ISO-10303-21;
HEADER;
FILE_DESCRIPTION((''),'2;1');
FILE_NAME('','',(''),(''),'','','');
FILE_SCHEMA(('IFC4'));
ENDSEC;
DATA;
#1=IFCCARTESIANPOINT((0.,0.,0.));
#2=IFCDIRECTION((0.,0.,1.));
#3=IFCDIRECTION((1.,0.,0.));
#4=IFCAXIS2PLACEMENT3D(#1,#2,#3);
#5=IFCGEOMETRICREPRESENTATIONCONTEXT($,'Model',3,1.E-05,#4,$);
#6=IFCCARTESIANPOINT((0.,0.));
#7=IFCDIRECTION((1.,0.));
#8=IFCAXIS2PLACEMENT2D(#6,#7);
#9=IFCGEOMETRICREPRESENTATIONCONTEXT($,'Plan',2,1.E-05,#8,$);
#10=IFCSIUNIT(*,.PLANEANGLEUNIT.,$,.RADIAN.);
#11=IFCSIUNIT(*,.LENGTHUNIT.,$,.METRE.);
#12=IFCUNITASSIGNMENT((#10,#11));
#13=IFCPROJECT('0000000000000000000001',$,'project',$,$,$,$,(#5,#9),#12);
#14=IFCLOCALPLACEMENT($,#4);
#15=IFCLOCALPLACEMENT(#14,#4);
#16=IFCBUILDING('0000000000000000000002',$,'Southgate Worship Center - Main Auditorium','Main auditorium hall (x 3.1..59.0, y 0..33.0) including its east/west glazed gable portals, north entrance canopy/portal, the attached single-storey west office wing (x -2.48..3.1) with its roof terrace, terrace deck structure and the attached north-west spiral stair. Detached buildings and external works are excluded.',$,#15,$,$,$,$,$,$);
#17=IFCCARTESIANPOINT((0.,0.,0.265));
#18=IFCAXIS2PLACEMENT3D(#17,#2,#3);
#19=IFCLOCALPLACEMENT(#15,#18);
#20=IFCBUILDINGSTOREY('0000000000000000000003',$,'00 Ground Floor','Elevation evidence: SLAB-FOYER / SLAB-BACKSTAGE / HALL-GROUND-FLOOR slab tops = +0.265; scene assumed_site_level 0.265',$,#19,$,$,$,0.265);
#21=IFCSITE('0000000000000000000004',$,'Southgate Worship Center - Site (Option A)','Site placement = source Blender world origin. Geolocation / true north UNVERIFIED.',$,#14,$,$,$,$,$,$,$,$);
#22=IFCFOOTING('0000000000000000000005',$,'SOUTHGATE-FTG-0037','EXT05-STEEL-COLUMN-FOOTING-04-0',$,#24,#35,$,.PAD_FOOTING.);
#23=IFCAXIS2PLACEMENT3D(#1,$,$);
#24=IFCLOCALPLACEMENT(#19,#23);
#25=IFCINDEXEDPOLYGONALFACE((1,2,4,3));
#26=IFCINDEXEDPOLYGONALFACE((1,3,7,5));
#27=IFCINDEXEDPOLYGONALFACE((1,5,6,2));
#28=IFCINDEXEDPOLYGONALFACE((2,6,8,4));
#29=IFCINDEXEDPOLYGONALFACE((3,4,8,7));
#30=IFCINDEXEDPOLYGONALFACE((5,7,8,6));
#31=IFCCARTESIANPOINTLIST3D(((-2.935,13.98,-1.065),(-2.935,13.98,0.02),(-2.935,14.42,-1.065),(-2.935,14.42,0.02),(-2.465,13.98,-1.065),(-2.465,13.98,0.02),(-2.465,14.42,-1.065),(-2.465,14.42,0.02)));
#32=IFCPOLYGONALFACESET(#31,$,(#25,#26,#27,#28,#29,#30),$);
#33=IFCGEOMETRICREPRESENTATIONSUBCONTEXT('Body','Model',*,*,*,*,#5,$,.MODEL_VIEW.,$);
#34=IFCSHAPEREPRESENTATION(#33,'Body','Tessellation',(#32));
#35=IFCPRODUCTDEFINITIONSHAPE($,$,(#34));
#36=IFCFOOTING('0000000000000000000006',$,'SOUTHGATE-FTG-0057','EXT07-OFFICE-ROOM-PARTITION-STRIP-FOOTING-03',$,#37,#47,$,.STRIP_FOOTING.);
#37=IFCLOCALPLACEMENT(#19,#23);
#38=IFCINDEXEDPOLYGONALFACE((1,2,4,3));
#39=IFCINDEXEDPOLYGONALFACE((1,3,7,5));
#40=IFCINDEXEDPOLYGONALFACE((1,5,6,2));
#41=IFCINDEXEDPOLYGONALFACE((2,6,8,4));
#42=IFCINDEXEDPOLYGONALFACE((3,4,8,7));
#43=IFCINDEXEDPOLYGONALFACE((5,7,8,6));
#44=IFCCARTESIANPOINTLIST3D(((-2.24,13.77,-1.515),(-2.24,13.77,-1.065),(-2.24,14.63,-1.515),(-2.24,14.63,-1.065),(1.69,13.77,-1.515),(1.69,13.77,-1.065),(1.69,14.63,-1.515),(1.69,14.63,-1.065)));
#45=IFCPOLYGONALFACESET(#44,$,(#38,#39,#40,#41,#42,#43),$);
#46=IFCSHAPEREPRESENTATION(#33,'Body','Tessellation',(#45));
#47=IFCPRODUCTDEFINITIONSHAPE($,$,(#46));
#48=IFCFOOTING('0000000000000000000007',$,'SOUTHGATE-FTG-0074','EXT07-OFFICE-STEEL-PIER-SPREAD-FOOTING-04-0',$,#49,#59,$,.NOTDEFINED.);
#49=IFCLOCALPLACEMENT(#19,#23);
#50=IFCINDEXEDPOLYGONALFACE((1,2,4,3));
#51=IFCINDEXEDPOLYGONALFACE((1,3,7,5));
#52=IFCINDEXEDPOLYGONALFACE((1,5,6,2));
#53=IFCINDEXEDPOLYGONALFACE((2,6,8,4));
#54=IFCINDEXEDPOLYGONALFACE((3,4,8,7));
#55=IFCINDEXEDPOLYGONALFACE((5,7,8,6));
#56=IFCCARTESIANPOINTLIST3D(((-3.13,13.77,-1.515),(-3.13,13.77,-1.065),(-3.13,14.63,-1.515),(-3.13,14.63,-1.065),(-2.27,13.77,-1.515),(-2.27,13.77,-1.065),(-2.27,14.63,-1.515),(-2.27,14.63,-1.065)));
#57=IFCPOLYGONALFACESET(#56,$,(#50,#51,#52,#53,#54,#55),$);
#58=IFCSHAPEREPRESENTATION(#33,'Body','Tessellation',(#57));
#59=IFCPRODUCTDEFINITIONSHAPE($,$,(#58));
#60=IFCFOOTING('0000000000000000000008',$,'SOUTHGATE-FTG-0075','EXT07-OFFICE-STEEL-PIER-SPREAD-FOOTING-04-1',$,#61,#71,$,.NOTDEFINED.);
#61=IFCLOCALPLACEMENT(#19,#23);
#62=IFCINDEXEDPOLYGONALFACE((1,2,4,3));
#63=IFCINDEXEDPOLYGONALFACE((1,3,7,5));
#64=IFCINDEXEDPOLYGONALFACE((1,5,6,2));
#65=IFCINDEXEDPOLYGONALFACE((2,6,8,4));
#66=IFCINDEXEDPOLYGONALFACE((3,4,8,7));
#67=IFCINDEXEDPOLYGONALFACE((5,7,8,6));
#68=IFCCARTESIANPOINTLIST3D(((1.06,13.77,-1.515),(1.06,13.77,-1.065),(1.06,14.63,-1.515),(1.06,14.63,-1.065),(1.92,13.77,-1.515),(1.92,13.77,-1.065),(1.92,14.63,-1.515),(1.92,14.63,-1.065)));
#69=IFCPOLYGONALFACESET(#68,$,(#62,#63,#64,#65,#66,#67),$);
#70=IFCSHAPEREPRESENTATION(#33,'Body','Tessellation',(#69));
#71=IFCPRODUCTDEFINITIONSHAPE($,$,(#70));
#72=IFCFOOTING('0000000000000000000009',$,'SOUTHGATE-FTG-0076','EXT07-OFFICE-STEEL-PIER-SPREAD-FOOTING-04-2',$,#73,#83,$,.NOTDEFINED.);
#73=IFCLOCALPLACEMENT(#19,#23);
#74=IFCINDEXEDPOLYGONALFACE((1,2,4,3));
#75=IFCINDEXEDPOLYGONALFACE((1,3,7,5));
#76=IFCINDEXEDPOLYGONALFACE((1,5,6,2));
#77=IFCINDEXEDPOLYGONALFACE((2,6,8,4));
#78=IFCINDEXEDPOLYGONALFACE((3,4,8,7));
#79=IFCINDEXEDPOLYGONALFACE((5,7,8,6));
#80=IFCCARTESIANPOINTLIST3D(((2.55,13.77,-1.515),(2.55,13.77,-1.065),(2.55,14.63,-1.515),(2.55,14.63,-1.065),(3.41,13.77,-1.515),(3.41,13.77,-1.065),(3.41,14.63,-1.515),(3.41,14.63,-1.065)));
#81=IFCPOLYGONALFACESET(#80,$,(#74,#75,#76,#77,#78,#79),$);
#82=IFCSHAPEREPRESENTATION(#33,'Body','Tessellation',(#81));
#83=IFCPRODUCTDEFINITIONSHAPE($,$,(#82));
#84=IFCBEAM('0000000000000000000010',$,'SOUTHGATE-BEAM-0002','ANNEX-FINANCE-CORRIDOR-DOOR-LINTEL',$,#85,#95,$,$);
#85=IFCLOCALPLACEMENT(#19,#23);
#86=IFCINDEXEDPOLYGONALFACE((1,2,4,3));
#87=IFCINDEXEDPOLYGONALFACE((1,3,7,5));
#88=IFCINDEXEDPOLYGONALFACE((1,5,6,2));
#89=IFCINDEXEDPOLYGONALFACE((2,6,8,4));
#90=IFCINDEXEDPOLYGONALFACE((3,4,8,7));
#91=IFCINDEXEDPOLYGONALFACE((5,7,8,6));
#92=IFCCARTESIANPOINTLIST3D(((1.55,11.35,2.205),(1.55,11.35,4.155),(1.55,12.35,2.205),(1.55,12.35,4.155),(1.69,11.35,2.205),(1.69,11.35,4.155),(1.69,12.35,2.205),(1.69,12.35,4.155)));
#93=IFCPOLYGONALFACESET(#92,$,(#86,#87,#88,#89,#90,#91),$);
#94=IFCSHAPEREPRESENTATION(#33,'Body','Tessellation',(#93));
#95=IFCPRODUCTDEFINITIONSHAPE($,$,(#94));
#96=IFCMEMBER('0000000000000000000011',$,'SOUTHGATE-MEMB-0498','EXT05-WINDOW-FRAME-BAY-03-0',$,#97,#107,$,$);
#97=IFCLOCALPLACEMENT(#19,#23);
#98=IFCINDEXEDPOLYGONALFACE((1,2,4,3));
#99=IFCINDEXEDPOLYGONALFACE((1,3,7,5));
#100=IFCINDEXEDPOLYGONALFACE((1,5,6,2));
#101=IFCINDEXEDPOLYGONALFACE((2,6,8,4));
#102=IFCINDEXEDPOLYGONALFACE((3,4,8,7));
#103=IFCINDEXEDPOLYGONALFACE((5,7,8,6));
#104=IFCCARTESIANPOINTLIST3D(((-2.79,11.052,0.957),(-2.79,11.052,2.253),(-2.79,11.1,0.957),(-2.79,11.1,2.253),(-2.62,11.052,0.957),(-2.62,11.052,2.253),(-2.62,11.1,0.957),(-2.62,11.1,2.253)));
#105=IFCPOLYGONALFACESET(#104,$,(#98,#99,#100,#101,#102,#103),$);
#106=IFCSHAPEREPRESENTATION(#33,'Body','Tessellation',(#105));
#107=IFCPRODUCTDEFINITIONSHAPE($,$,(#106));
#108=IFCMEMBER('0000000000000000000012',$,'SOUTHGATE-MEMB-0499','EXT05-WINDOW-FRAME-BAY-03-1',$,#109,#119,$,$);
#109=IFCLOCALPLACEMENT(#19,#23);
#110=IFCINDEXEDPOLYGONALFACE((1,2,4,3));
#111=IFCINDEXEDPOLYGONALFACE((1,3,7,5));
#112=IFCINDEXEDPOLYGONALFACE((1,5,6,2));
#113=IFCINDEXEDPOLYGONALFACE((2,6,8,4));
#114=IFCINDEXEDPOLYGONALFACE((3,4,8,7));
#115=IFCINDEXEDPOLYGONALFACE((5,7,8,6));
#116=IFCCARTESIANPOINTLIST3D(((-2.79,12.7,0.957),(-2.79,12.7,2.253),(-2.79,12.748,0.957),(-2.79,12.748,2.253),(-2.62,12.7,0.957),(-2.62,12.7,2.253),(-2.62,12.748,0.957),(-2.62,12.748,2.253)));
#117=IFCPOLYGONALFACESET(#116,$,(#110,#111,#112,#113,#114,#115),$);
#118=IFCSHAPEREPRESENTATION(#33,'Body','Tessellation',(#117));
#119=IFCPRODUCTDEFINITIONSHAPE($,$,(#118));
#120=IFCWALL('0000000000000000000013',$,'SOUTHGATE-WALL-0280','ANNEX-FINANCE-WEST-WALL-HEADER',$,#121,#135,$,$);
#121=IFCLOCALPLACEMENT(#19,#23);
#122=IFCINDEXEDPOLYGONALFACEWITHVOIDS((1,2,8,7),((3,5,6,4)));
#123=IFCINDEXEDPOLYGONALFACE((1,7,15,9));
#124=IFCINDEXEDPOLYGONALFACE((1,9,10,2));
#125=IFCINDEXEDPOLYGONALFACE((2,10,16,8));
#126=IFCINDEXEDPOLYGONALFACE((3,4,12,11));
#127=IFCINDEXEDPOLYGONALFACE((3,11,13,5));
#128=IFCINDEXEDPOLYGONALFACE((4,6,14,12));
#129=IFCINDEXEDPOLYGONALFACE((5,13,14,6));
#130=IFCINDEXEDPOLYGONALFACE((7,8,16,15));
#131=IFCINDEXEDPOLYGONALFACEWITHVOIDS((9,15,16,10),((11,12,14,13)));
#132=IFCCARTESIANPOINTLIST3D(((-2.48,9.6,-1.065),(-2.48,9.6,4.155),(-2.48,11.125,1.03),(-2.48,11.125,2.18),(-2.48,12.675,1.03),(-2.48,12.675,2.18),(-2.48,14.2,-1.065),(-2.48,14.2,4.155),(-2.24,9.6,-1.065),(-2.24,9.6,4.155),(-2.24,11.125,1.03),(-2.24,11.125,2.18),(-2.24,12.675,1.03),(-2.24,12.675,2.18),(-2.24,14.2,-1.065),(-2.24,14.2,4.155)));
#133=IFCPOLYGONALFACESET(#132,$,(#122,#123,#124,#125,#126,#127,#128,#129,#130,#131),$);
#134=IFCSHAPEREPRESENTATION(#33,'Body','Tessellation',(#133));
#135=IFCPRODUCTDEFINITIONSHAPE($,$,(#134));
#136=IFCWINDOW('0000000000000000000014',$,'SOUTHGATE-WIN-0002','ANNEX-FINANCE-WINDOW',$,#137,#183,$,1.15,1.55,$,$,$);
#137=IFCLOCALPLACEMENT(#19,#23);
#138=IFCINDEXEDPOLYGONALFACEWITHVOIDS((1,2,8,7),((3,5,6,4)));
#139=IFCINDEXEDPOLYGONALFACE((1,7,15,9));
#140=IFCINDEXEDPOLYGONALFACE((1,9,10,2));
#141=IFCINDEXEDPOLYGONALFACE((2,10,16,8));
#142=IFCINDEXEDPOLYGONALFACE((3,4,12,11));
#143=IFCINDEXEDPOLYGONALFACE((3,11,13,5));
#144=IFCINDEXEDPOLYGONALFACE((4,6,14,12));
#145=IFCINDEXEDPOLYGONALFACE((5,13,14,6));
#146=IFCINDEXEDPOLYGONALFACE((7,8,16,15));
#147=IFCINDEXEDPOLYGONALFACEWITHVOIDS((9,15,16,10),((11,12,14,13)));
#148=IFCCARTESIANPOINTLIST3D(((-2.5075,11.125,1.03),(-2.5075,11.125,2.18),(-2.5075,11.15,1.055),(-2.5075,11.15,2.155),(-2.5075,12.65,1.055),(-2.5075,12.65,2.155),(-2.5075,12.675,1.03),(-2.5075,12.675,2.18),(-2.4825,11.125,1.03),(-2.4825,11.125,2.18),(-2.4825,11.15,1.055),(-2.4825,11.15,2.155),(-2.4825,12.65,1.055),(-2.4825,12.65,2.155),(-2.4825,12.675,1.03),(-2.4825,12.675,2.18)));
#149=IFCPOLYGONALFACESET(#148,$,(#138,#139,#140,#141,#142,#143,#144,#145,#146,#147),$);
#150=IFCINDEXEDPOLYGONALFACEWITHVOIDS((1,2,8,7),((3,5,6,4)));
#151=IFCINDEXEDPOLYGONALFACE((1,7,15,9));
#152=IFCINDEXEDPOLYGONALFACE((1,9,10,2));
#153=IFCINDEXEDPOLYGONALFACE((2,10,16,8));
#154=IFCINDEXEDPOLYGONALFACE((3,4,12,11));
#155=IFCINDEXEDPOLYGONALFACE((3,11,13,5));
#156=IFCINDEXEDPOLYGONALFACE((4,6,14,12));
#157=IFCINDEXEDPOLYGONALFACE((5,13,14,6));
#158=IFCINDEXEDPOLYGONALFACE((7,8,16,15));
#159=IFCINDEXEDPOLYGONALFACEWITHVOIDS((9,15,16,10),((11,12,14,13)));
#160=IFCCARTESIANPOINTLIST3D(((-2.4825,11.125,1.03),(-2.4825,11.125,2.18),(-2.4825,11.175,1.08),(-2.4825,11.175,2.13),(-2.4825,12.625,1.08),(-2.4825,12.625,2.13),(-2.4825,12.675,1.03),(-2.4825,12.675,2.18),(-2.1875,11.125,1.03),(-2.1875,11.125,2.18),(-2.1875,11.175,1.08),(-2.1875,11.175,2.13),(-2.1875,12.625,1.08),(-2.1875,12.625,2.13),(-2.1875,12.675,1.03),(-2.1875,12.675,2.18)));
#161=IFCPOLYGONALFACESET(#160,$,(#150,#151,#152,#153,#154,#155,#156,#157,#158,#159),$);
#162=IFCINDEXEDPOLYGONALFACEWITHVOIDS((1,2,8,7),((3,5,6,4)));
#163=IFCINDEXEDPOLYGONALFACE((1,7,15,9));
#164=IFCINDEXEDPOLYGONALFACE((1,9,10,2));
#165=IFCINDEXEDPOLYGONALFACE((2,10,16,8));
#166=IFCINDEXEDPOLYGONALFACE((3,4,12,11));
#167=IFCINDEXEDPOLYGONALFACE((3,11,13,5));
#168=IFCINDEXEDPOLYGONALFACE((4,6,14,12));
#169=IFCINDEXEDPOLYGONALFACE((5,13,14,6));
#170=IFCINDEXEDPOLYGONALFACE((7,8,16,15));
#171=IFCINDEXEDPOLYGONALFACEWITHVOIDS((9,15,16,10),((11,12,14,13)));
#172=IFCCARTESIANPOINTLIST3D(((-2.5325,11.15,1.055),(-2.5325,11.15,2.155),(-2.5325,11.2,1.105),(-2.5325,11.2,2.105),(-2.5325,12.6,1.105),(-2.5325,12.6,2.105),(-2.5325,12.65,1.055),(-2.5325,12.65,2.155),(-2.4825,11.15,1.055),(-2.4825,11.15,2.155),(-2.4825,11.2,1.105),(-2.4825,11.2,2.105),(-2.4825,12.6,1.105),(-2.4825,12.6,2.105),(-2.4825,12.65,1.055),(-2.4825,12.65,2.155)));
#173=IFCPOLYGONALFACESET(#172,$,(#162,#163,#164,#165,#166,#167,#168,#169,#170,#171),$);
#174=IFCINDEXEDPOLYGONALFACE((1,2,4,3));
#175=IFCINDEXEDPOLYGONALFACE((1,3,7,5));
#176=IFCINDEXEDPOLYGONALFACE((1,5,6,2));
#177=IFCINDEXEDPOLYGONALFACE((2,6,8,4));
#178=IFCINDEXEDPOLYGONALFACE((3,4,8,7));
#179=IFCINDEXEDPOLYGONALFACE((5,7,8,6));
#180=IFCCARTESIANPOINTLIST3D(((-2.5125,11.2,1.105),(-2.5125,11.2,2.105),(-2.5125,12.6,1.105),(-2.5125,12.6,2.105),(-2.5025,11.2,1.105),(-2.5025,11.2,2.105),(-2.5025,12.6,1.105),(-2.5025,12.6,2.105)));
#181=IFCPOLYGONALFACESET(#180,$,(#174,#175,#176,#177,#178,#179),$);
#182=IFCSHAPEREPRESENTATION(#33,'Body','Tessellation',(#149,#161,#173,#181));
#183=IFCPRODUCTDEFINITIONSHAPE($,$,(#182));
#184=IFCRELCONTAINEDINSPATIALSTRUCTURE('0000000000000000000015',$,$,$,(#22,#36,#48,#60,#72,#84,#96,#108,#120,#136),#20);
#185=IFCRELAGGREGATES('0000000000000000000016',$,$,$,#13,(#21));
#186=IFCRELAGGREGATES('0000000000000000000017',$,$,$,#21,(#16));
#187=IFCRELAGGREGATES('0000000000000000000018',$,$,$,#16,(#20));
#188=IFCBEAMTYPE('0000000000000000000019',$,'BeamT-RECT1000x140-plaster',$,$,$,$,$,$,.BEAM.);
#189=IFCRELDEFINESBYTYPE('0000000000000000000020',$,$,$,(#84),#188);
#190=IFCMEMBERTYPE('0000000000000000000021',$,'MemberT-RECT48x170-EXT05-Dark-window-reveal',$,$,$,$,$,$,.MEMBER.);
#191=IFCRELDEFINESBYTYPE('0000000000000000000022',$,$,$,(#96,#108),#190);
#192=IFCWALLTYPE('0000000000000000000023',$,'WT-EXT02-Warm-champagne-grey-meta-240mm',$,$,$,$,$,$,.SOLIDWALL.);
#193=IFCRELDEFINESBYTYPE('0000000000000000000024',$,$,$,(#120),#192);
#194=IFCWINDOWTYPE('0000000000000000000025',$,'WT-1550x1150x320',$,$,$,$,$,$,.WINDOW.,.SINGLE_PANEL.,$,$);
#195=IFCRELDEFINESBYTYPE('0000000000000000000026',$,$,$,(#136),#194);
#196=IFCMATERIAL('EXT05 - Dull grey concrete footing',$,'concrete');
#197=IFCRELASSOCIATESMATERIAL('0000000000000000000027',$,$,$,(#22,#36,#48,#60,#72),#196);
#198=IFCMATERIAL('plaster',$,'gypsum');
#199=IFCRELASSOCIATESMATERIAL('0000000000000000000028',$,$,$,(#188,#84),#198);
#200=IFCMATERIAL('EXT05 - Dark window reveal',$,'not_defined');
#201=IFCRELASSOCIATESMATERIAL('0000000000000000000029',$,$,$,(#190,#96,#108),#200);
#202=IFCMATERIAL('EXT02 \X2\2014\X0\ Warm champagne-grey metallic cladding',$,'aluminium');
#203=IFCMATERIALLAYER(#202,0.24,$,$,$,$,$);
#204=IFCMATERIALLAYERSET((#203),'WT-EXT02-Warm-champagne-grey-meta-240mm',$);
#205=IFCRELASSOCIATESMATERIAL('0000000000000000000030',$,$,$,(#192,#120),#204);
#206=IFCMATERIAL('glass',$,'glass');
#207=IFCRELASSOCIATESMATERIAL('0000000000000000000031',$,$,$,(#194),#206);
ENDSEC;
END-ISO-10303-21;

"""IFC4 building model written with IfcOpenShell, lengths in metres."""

from ifc_helpers import new_model, si_unit, frame, frame_2d, origin_with_axes, origin_2d, origin_2d_with_axis, place, context, subcontext, project, spatial, line, indexed_curve, rectangle, outline, extrude, source, transform, mapped, material, layer, layer_set, layer_usage, material_profile, profile_set, profile_usage, type_object, type_shapes, element, fill, save


model = new_model("IFC4")

# Units and contexts
model_context = context("Model", 3, precision=1e-05, world=origin_with_axes())
plan_context = context("Plan", 2, precision=1e-05, world=origin_2d_with_axis())
body_context = subcontext(model_context, "Body", "Model", "MODEL_VIEW")
ifc_project = project(units=[si_unit("PLANEANGLEUNIT", "RADIAN"), si_unit("LENGTHUNIT", "METRE")], contexts=[model_context, plan_context])

# Site, building, storey
site_placement = place(None, origin_with_axes())
site = spatial("IfcSite", under=ifc_project, at=site_placement, Name="Southgate Worship Center - Site (Option A)", Description="Site placement = source Blender world origin. Geolocation / true north UNVERIFIED.")
building_placement = place(site_placement, origin_with_axes())
building = spatial("IfcBuilding", under=site, at=building_placement, Name="Southgate Worship Center - Main Auditorium", Description="Main auditorium hall (x 3.1..59.0, y 0..33.0) including its east/west glazed gable portals, north entrance canopy/portal, the attached single-storey west office wing (x -2.48..3.1) with its roof terrace, terrace deck structure and the attached north-west spiral stair. Detached buildings and external works are excluded.")
storey_placement = place(building_placement, frame((0.0, 0.0, 0.265), z_axis=(0.0, 0.0, 1.0), x_axis=(1.0, 0.0, 0.0)))
storey = spatial("IfcBuildingStorey", under=building, at=storey_placement, Name="00 Ground Floor", Description="Elevation evidence: SLAB-FOYER / SLAB-BACKSTAGE / HALL-GROUND-FLOOR slab tops = +0.265; scene assumed_site_level 0.265", Elevation=0.265)

# Footings
ifc_material_1 = material(Name="EXT05 - Dull grey concrete footing", Category="concrete")
footing_1_placement = place(storey_placement, frame((-2.935, 13.98, -1.065), z_axis=(0.0, 0.0, 1.0), x_axis=(1.0, 0.0, 0.0)))
element("IfcFooting", 1, at=footing_1_placement, inside=storey, material=ifc_material_1, Name="SOUTHGATE-FTG-0037", Description="EXT05-STEEL-COLUMN-FOOTING-04-0", PredefinedType="PAD_FOOTING", context=body_context, shape_type="SweptSolid", body=[
    extrude(rectangle(XDim=0.44, YDim=0.47, at=origin_2d()), frame((0.235, 0.22, 0.0), z_axis=(0.0, 0.0, 1.0), x_axis=(0.0, 1.0, 0.0)), (0.0, 0.0, 1.0), 1.085),
])
footing_2_placement = place(storey_placement, frame((-2.24, 13.77, -1.515), z_axis=(0.0, 0.0, 1.0), x_axis=(1.0, 0.0, 0.0)))
element("IfcFooting", 2, at=footing_2_placement, inside=storey, material=ifc_material_1, Name="SOUTHGATE-FTG-0057", Description="EXT07-OFFICE-ROOM-PARTITION-STRIP-FOOTING-03", PredefinedType="STRIP_FOOTING", context=body_context, shape_type="SweptSolid", body=[
    extrude(rectangle(XDim=0.86, YDim=3.93, at=origin_2d()), frame((1.965, 0.43, 0.0), z_axis=(0.0, 0.0, 1.0), x_axis=(0.0, -1.0, 0.0)), (0.0, 0.0, 1.0), 0.45),
])
footing_3_placement = place(storey_placement, frame((-3.13, 13.77, -1.515), z_axis=(0.0, 0.0, 1.0), x_axis=(1.0, 0.0, 0.0)))
element("IfcFooting", 3, at=footing_3_placement, inside=storey, material=ifc_material_1, Name="SOUTHGATE-FTG-0074", Description="EXT07-OFFICE-STEEL-PIER-SPREAD-FOOTING-04-0", PredefinedType="NOTDEFINED", context=body_context, shape_type="SweptSolid", body=[
    extrude(rectangle(XDim=0.86, YDim=0.86, at=origin_2d()), frame((0.43, 0.43, 0.0), z_axis=(0.0, 0.0, 1.0), x_axis=(1.0, 0.0, 0.0)), (0.0, 0.0, 1.0), 0.45),
])
footing_4_placement = place(storey_placement, frame((1.06, 13.77, -1.515), z_axis=(0.0, 0.0, 1.0), x_axis=(1.0, 0.0, 0.0)))
element("IfcFooting", 4, at=footing_4_placement, inside=storey, material=ifc_material_1, Name="SOUTHGATE-FTG-0075", Description="EXT07-OFFICE-STEEL-PIER-SPREAD-FOOTING-04-1", PredefinedType="NOTDEFINED", context=body_context, shape_type="SweptSolid", body=[
    extrude(rectangle(XDim=0.86, YDim=0.86, at=origin_2d()), frame((0.43, 0.43, 0.0), z_axis=(0.0, 0.0, 1.0), x_axis=(1.0, 0.0, 0.0)), (0.0, 0.0, 1.0), 0.45),
])
footing_5_placement = place(storey_placement, frame((2.55, 13.77, -1.515), z_axis=(0.0, 0.0, 1.0), x_axis=(1.0, 0.0, 0.0)))
element("IfcFooting", 5, at=footing_5_placement, inside=storey, material=ifc_material_1, Name="SOUTHGATE-FTG-0076", Description="EXT07-OFFICE-STEEL-PIER-SPREAD-FOOTING-04-2", PredefinedType="NOTDEFINED", context=body_context, shape_type="SweptSolid", body=[
    extrude(rectangle(XDim=0.86, YDim=0.86, at=origin_2d()), frame((0.43, 0.43, 0.0), z_axis=(0.0, 0.0, 1.0), x_axis=(1.0, 0.0, 0.0)), (0.0, 0.0, 1.0), 0.45),
])

# Beam
ifc_material_2 = material(Name="plaster", Category="gypsum")
ifc_material_profile_1 = material_profile(ifc_material_2, rectangle(XDim=1.0, YDim=0.14, at=origin_2d()))
ifc_profile_set_1 = profile_set([ifc_material_profile_1], Name="BeamT-RECT1000x140-plaster")
ifc_profile_usage_1 = profile_usage(ifc_profile_set_1)
beam_type = type_object("IfcBeamType", Name="BeamT-RECT1000x140-plaster", PredefinedType="BEAM", material=ifc_profile_set_1)
beam_placement = place(storey_placement, frame((1.62, 11.85, 2.205), z_axis=(0.0, 0.0, 1.0), x_axis=(0.0, 1.0, 0.0)))
element("IfcBeam", 6, at=beam_placement, inside=storey, type_object=beam_type, material=ifc_profile_usage_1, Name="SOUTHGATE-BEAM-0002", Description="ANNEX-FINANCE-CORRIDOR-DOOR-LINTEL", context=body_context, shape_type="SweptSolid", body=[
    extrude(rectangle(XDim=1.0, YDim=0.14, at=origin_2d()), origin_with_axes(), (0.0, 0.0, 1.0), 1.95),
])

# Members
ifc_material_3 = material(Name="EXT05 - Dark window reveal", Category="not_defined")
ifc_material_profile_2 = material_profile(ifc_material_3, rectangle(XDim=0.048, YDim=0.17, at=origin_2d()))
ifc_profile_set_2 = profile_set([ifc_material_profile_2], Name="MemberT-RECT48x170-EXT05-Dark-window-reveal")
ifc_profile_usage_2 = profile_usage(ifc_profile_set_2)
member_type = type_object("IfcMemberType", Name="MemberT-RECT48x170-EXT05-Dark-window-reveal", PredefinedType="MEMBER", material=ifc_profile_set_2)
for number, where, z_axis, x_axis, name, description in (
    (7, (-2.705, 11.076, 0.957), (0.0, 0.0, 1.0), (0.0, 1.0, 0.0), "SOUTHGATE-MEMB-0498", "EXT05-WINDOW-FRAME-BAY-03-0"),
    (8, (-2.705, 12.724, 0.957), (0.0, 0.0, 1.0), (0.0, 1.0, 0.0), "SOUTHGATE-MEMB-0499", "EXT05-WINDOW-FRAME-BAY-03-1"),
):
    element("IfcMember", number, at=place(storey_placement, frame(where, z_axis=z_axis, x_axis=x_axis)), inside=storey, type_object=member_type, material=ifc_profile_usage_2, Name=name, Description=description, context=body_context, shape_type="SweptSolid", body=[
        extrude(rectangle(XDim=0.048, YDim=0.17, at=origin_2d()), origin_with_axes(), (0.0, 0.0, 1.0), 1.296),
    ])

# Wall, opening, window
ifc_material_4 = material(Name="EXT02 — Warm champagne-grey metallic cladding", Category="aluminium")
ifc_layer = layer(ifc_material_4, 0.24)
ifc_layer_set = layer_set([ifc_layer], Name="WT-EXT02-Warm-champagne-grey-meta-240mm")
ifc_layer_usage = layer_usage(ifc_layer_set, "AXIS2", "POSITIVE", 0.0)
wall_type = type_object("IfcWallType", Name="WT-EXT02-Warm-champagne-grey-meta-240mm", PredefinedType="SOLIDWALL", material=ifc_layer_set)
wall_1_placement = place(storey_placement, frame((-2.24, 9.6, -1.065), z_axis=(0.0, 0.0, 1.0), x_axis=(0.0, 1.0, 0.0)))
wall_1 = element("IfcWall", 9, at=wall_1_placement, inside=storey, type_object=wall_type, material=ifc_layer_usage, Name="SOUTHGATE-WALL-0280", Description="ANNEX-FINANCE-WEST-WALL-HEADER", context=body_context, shape_type="SweptSolid", body=[
    extrude(outline(indexed_curve([(0.0, 0.0), (0.0, 0.24), (4.6, 0.24), (4.6, 0.0), (0.0, 0.0)], self_intersect=False)), origin_with_axes(), (0.0, 0.0, 1.0), 5.22),
])
opening_1_placement = place(wall_1_placement, origin_with_axes())
opening_1 = element("IfcOpeningElement", 10, at=opening_1_placement, cuts=wall_1, PredefinedType="OPENING", context=body_context, shape_type="SweptSolid", body=[
    extrude(rectangle(XDim=1.55, YDim=0.34, at=frame_2d((2.3, 0.12))), frame((0.0, 0.0, 2.095), z_axis=(0.0, 0.0, 1.0), x_axis=(1.0, 0.0, 0.0)), (0.0, 0.0, 1.0), 1.15),
])
ifc_material_5 = material(Name="glass", Category="glass")
window_type = type_object("IfcWindowType", Name="WT-1550x1150x320", PartitioningType="SINGLE_PANEL", PredefinedType="WINDOW", material=ifc_material_5)
shared_shape_1 = source(origin_with_axes(), body_context, "Body", "SweptSolid", [
    extrude(outline(indexed_curve([(0.0, 0.0), (1.55, 0.0), (1.55, 1.15), (0.0, 1.15)], segments=[line(1, 2, 3, 4, 1)]), holes=[indexed_curve([(0.025, 0.025), (1.525, 0.025), (1.525, 1.125), (0.025, 1.125)], segments=[line(1, 2, 3, 4, 1)])]), frame((0.0, 0.345, 0.0), z_axis=(0.0, -1.0, 0.0), x_axis=(1.0, 0.0, 0.0)), (0.0, 0.0, -1.0), 0.025),
    extrude(outline(indexed_curve([(0.0, 0.0), (1.55, 0.0), (1.55, 1.15), (0.0, 1.15)], segments=[line(1, 2, 3, 4, 1)]), holes=[indexed_curve([(0.05, 0.05), (1.5, 0.05), (1.5, 1.1), (0.05, 1.1)], segments=[line(1, 2, 3, 4, 1)])]), frame((0.0, 0.05, 0.0), z_axis=(0.0, -1.0, 0.0), x_axis=(1.0, 0.0, 0.0)), (0.0, 0.0, -1.0), 0.295),
    extrude(outline(indexed_curve([(0.0, 0.0), (1.5, 0.0), (1.5, 1.1), (0.0, 1.1)], segments=[line(1, 2, 3, 4, 1)]), holes=[indexed_curve([(0.05, 0.05), (1.45, 0.05), (1.45, 1.05), (0.05, 1.05)], segments=[line(1, 2, 3, 4, 1)])]), frame((0.025, 0.345, 0.025), z_axis=(0.0, -1.0, 0.0), x_axis=(1.0, 0.0, 0.0)), (0.0, 0.0, -1.0), 0.05),
    extrude(outline(indexed_curve([(0.05, 0.05), (1.45, 0.05), (1.45, 1.05), (0.05, 1.05)], segments=[line(1, 2, 3, 4, 1)])), frame((0.025, 0.365, 0.025), z_axis=(0.0, -1.0, 0.0), x_axis=(1.0, 0.0, 0.0)), (0.0, 0.0, -1.0), 0.01),
])
type_shapes(window_type, [shared_shape_1])
window_placement = place(storey_placement, frame((-2.1375, 11.125, 1.03), z_axis=(0.0, 0.0, 1.0), x_axis=(0.0, 1.0, 0.0)))
window = element("IfcWindow", 11, at=window_placement, inside=storey, type_object=window_type, Name="SOUTHGATE-WIN-0002", Description="ANNEX-FINANCE-WINDOW", OverallHeight=1.15, OverallWidth=1.55, context=body_context, shape_type="MappedRepresentation", body=[
    mapped(shared_shape_1, transform((0.0, 0.0, 0.0), x_axis=(1.0, 0.0, 0.0), y_axis=(0.0, 1.0, 0.0), z_axis=(0.0, 0.0, 1.0), scale=1.0)),
])
fill(opening_1, window)

save(model, "model.ifc")
